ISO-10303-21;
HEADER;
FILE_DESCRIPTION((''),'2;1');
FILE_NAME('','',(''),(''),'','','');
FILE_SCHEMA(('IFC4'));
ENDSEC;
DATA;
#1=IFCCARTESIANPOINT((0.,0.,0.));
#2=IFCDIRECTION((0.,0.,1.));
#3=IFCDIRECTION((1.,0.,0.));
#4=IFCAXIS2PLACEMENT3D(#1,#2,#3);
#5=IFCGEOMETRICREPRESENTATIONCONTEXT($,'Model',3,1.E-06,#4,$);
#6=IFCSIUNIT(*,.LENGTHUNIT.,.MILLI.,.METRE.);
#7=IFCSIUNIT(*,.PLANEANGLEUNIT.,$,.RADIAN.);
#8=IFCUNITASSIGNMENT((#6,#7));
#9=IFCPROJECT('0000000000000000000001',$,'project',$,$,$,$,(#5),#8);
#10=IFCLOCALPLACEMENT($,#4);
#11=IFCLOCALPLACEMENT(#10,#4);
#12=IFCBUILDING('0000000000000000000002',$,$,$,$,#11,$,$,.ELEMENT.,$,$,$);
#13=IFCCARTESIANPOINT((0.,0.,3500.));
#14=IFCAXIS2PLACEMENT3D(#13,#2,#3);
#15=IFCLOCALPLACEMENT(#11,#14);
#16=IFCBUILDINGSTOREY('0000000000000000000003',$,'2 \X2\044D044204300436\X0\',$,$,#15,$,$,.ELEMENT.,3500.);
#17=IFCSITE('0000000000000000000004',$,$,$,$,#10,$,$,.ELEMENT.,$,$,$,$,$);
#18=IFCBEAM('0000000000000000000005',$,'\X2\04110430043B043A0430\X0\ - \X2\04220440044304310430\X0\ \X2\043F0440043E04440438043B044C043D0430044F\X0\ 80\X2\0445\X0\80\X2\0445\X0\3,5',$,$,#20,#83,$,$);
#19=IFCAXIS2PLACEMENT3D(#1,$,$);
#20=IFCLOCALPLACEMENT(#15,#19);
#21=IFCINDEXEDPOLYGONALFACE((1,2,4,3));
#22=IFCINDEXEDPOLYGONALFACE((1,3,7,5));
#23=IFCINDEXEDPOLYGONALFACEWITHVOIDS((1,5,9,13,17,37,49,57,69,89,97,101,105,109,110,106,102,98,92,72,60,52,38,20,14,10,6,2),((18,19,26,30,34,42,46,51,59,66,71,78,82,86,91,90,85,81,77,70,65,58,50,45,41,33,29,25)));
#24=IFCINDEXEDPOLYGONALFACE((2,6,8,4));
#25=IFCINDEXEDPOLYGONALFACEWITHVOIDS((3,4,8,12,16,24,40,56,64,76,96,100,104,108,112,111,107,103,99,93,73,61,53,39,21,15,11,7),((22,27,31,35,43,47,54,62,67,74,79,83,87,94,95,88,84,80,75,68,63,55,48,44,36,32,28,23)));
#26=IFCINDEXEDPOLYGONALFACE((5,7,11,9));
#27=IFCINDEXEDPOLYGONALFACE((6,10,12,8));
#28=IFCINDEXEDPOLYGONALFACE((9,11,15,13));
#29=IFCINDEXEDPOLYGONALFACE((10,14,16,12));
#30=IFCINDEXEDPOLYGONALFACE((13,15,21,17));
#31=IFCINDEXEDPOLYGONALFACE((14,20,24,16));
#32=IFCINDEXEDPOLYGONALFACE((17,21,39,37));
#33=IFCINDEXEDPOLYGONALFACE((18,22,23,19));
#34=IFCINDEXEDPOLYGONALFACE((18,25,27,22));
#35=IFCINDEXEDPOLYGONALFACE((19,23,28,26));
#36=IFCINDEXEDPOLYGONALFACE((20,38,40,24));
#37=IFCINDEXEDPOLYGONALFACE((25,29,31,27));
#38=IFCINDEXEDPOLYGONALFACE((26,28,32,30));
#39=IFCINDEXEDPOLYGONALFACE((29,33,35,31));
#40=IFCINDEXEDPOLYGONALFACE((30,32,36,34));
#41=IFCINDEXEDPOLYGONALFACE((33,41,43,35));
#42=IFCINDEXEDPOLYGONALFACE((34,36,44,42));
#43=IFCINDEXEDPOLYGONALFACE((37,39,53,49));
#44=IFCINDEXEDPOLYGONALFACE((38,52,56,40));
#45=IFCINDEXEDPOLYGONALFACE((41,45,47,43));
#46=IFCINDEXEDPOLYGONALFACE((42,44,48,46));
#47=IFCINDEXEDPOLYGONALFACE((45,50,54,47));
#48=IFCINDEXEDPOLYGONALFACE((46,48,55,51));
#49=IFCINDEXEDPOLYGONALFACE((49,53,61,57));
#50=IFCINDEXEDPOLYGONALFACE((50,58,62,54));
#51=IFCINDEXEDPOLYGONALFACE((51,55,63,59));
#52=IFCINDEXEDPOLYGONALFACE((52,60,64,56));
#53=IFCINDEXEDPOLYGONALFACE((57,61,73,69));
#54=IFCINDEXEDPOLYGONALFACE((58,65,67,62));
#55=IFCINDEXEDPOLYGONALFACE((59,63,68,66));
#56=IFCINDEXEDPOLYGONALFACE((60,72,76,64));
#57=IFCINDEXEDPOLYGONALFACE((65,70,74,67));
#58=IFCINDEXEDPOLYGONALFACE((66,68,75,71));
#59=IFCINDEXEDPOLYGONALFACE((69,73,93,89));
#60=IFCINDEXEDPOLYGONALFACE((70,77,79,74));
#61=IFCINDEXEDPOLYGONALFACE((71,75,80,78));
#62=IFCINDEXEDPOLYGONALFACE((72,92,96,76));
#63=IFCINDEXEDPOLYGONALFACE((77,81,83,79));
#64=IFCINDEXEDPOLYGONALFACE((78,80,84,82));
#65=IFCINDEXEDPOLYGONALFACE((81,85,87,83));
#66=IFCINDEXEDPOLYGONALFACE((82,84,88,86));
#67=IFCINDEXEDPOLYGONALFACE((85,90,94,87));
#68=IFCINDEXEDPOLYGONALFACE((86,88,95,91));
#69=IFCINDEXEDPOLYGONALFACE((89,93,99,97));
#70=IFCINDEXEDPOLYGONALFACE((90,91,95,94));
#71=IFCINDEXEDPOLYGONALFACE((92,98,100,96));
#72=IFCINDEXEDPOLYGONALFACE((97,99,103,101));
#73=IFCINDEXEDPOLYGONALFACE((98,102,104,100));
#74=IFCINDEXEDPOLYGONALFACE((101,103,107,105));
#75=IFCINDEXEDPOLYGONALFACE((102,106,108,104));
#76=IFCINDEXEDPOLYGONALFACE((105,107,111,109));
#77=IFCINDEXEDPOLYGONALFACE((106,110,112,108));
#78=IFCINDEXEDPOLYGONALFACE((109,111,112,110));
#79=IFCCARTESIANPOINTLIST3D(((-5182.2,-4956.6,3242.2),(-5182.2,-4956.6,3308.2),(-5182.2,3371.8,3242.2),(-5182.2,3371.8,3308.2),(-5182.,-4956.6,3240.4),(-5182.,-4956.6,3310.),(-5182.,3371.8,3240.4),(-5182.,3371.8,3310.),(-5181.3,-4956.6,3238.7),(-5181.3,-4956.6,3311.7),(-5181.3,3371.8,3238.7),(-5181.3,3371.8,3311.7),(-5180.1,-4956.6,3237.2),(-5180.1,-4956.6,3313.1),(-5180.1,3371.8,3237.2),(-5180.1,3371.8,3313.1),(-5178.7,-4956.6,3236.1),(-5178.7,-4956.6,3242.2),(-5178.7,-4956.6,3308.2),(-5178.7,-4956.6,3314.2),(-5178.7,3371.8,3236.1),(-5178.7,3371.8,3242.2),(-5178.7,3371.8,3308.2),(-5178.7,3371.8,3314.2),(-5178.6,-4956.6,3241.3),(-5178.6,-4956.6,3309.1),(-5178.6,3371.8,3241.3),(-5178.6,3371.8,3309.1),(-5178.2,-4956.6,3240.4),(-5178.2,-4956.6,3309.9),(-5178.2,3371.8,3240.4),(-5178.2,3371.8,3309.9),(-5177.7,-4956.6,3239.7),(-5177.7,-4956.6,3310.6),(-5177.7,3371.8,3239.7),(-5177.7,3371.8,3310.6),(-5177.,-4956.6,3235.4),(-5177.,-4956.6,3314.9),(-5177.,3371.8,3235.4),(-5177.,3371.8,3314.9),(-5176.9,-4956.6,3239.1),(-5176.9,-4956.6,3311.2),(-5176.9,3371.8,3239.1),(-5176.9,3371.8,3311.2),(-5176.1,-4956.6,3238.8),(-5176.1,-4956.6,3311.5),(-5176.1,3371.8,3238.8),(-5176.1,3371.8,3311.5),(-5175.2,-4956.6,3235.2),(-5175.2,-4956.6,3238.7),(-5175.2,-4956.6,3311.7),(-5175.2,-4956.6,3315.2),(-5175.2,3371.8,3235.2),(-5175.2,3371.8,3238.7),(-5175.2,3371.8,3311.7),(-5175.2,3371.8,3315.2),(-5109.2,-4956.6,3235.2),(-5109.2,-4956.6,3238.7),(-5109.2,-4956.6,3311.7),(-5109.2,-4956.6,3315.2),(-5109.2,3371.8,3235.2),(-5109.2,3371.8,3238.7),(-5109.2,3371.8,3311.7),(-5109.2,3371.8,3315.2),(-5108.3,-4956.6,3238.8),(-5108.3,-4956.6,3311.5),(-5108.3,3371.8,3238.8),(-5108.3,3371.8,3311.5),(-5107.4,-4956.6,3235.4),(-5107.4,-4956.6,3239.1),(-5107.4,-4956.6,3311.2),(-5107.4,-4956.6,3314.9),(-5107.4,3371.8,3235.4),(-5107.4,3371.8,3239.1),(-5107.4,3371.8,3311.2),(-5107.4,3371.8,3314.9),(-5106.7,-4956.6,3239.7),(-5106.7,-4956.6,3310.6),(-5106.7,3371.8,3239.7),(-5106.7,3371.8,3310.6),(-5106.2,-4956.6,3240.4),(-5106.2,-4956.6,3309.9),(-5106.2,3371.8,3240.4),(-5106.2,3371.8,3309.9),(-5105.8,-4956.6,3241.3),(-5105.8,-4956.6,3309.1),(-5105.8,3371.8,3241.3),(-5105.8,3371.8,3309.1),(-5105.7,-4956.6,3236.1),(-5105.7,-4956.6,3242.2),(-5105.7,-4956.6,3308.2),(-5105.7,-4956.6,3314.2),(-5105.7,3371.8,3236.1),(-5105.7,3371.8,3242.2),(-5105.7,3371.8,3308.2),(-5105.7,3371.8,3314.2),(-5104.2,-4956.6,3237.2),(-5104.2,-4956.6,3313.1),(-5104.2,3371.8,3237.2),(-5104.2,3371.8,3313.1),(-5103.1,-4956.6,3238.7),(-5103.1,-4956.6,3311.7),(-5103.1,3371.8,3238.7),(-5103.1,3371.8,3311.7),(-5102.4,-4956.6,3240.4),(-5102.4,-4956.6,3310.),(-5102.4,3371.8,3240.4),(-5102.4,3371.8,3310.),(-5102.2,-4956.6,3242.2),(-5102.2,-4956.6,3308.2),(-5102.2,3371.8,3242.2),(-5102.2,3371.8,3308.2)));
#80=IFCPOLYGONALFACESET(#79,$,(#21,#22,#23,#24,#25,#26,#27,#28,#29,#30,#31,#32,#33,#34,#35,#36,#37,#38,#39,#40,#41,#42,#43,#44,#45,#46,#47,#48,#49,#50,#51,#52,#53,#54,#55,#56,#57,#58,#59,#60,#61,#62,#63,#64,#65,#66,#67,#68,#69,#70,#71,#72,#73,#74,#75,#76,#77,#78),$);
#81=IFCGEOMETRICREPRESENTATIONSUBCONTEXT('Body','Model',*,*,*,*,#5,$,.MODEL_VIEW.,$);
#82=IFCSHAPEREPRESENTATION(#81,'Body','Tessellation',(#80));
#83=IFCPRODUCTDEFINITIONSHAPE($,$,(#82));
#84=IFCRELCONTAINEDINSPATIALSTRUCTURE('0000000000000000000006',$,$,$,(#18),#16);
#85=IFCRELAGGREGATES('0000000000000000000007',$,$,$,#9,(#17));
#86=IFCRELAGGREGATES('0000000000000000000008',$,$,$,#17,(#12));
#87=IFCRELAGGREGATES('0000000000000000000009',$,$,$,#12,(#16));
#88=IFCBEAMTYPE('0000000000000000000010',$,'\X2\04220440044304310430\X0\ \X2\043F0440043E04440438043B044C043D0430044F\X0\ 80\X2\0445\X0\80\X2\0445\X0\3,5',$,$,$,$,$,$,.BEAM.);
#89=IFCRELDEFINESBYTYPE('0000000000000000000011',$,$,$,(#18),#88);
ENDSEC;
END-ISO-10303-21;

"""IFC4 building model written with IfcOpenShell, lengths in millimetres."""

from ifc_helpers import new_model, si_unit, frame, origin_with_axes, place, context, subcontext, project, spatial, line, arc, indexed_curve, outline, extrude, source, transform, mapped, type_object, element, save


model = new_model("IFC4")

# Units and contexts
model_context = context("Model", 3, precision=1e-06, world=origin_with_axes())
body_context = subcontext(model_context, "Body", "Model", "MODEL_VIEW")
ifc_project = project(units=[si_unit("LENGTHUNIT", "METRE", prefix="MILLI"), si_unit("PLANEANGLEUNIT", "RADIAN")], contexts=[model_context])

# Site, building, storey
site_placement = place(None, origin_with_axes())
site = spatial("IfcSite", under=ifc_project, at=site_placement, CompositionType="ELEMENT")
building_placement = place(site_placement, origin_with_axes())
building = spatial("IfcBuilding", under=site, at=building_placement, CompositionType="ELEMENT")
storey_placement = place(building_placement, frame((0.0, 0.0, 3500.0), z_axis=(0.0, 0.0, 1.0), x_axis=(1.0, 0.0, 0.0)))
storey = spatial("IfcBuildingStorey", under=building, at=storey_placement, Name="2 этаж", CompositionType="ELEMENT", Elevation=3500.0)

# Beam
beam_type = type_object("IfcBeamType", Name="Труба профильная 80х80х3,5", PredefinedType="BEAM")
shared_shape_1 = source(origin_with_axes(), body_context, "Body", "SweptSolid", [
    extrude(outline(indexed_curve([(-40.0, -73.0), (-37.9, -77.9), (-33.0, -80.0), (33.0, -80.0), (37.9, -77.9), (40.0, -73.0), (40.0, -7.0), (37.9, -2.1), (33.0, 0.0), (-33.0, 0.0), (-37.9, -2.1), (-40.0, -7.0)], segments=[arc(1, 2, 3), line(3, 4), arc(4, 5, 6), line(6, 7), arc(7, 8, 9), line(9, 10), arc(10, 11, 12), line(12, 1)]), holes=[indexed_curve([(-36.5, -7.0), (-35.5, -4.5), (-33.0, -3.5), (33.0, -3.5), (35.5, -4.5), (36.5, -7.0), (36.5, -73.0), (35.5, -75.5), (33.0, -76.5), (-33.0, -76.5), (-35.5, -75.5), (-36.5, -73.0)], segments=[arc(1, 2, 3), line(3, 4), arc(4, 5, 6), line(6, 7), arc(7, 8, 9), line(9, 10), arc(10, 11, 12), line(12, 1)])]), origin_with_axes(), (0.0, 0.0, -1.0), 8328.4),
])
beam_1_placement = place(storey_placement, frame((-5142.2, 3371.8, 3315.2), z_axis=(0.0, 1.0, 0.0), x_axis=(-1.0, 0.0, 0.0)))
element("IfcBeam", 1, at=beam_1_placement, inside=storey, type_object=beam_type, Name="Балка - Труба профильная 80х80х3,5", context=body_context, shape_type="MappedRepresentation", body=[
    mapped(shared_shape_1, transform((0.0, 0.0, 0.0), x_axis=(1.0, 0.0, 0.0), y_axis=(0.0, 1.0, 0.0), z_axis=(0.0, 0.0, 1.0), scale=1.0)),
])

save(model, "model.ifc")
